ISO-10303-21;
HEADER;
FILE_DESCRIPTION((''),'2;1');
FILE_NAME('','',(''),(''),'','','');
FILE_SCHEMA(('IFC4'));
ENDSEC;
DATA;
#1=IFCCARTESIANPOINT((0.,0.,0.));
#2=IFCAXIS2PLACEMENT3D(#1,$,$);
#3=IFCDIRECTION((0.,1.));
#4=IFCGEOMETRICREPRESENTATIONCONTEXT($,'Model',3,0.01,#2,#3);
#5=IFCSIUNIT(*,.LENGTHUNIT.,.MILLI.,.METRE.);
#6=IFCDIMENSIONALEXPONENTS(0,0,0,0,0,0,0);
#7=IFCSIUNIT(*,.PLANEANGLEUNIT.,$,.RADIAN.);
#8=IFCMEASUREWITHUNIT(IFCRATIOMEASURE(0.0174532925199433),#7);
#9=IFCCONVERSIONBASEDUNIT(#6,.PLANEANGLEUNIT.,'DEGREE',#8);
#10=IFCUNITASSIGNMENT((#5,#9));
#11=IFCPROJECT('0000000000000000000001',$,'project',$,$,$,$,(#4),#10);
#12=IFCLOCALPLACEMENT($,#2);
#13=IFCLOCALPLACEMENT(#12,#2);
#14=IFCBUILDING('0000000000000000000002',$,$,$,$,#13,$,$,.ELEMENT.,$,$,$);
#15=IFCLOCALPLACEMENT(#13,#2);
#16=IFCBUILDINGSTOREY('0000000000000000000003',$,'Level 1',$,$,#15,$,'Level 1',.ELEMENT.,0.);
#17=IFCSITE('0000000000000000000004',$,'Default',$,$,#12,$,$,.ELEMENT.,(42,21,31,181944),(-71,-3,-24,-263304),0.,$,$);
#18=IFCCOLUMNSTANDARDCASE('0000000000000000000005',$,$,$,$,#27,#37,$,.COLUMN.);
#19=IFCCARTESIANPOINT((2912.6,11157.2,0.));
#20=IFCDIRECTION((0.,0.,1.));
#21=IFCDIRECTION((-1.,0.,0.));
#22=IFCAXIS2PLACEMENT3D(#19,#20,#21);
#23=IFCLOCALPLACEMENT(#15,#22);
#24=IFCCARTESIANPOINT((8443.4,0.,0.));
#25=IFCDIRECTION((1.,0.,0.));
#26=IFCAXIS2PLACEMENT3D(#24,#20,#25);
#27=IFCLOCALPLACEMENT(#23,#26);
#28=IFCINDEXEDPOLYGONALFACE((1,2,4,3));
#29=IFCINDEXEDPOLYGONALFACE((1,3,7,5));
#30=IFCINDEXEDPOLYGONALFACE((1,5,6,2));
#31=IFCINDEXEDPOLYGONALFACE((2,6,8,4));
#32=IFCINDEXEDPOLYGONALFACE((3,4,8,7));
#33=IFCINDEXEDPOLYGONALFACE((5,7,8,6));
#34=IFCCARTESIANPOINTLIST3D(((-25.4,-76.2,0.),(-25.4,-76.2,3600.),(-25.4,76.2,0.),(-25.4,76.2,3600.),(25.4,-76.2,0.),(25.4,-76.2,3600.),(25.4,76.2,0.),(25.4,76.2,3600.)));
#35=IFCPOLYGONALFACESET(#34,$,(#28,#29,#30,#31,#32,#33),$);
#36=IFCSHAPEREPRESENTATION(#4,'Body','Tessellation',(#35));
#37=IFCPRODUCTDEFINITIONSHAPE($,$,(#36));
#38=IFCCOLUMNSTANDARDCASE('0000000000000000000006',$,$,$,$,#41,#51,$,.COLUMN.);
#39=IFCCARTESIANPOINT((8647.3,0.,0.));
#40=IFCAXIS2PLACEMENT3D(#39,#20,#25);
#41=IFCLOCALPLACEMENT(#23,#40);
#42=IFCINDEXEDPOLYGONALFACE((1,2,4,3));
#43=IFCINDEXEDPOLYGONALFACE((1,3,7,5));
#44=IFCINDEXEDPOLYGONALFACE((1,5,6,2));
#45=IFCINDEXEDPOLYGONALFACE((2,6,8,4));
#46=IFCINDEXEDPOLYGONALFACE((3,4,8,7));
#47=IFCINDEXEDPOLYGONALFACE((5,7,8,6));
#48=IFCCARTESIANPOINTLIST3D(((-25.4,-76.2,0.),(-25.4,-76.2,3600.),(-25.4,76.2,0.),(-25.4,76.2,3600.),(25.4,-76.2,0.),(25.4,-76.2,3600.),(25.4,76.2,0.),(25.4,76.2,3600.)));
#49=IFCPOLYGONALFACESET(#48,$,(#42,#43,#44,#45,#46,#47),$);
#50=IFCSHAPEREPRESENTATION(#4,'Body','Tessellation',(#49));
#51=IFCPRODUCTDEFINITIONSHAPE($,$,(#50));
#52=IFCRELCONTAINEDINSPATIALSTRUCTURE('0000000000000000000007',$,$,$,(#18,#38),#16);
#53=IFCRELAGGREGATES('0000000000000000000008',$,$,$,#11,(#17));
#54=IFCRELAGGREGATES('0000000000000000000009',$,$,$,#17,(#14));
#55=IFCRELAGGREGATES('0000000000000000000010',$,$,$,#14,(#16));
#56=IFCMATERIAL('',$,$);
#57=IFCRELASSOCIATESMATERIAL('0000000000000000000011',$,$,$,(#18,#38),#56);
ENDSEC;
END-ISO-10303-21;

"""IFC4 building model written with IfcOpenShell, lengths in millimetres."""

from ifc_helpers import new_model, entity, si_unit, converted_unit, direction, frame, origin, place, context, project, spatial, rectangle, extrude, material, element, save


model = new_model("IFC4")

# Units and contexts
model_context = context("Model", 3, precision=0.01, world=origin(), true_north=direction((0.0, 1.0)))
ifc_project = project(units=[si_unit("LENGTHUNIT", "METRE", prefix="MILLI"), converted_unit("PLANEANGLEUNIT", "DEGREE", entity("IfcRatioMeasure", 0.0174532925199433), si_unit("PLANEANGLEUNIT", "RADIAN"), dimensions=[0, 0, 0, 0, 0, 0, 0])], contexts=[model_context])

# Site, building, storey
site_placement = place(None, origin())
site = spatial("IfcSite", under=ifc_project, at=site_placement, Name="Default", CompositionType="ELEMENT", RefLatitude=(42, 21, 31, 181944), RefLongitude=(-71, -3, -24, -263304), RefElevation=0.0)
building_placement = place(site_placement, origin())
building = spatial("IfcBuilding", under=site, at=building_placement, CompositionType="ELEMENT")
storey_placement = place(building_placement, origin())
storey = spatial("IfcBuildingStorey", under=building, at=storey_placement, Name="Level 1", LongName="Level 1", CompositionType="ELEMENT", Elevation=0.0)

# Columns
ifc_material_1 = material(Name="")
placement_1 = place(storey_placement, frame((2912.6, 11157.2, 0.0), z_axis=(0.0, 0.0, 1.0), x_axis=(-1.0, 0.0, 0.0)))
for number, where, z_axis, x_axis in (
    (1, (8443.4, 0.0, 0.0), (0.0, 0.0, 1.0), (1.0, 0.0, 0.0)),
    (2, (8647.3, 0.0, 0.0), (0.0, 0.0, 1.0), (1.0, 0.0, 0.0)),
):
    element("IfcColumnStandardCase", number, at=place(placement_1, frame(where, z_axis=z_axis, x_axis=x_axis)), inside=storey, material=ifc_material_1, PredefinedType="COLUMN", context=model_context, shape_type="SweptSolid", body=[
        extrude(rectangle(XDim=50.8, YDim=152.4), origin(), (0.0, 0.0, 1.0), 3600.0),
    ])

save(model, "model.ifc")
